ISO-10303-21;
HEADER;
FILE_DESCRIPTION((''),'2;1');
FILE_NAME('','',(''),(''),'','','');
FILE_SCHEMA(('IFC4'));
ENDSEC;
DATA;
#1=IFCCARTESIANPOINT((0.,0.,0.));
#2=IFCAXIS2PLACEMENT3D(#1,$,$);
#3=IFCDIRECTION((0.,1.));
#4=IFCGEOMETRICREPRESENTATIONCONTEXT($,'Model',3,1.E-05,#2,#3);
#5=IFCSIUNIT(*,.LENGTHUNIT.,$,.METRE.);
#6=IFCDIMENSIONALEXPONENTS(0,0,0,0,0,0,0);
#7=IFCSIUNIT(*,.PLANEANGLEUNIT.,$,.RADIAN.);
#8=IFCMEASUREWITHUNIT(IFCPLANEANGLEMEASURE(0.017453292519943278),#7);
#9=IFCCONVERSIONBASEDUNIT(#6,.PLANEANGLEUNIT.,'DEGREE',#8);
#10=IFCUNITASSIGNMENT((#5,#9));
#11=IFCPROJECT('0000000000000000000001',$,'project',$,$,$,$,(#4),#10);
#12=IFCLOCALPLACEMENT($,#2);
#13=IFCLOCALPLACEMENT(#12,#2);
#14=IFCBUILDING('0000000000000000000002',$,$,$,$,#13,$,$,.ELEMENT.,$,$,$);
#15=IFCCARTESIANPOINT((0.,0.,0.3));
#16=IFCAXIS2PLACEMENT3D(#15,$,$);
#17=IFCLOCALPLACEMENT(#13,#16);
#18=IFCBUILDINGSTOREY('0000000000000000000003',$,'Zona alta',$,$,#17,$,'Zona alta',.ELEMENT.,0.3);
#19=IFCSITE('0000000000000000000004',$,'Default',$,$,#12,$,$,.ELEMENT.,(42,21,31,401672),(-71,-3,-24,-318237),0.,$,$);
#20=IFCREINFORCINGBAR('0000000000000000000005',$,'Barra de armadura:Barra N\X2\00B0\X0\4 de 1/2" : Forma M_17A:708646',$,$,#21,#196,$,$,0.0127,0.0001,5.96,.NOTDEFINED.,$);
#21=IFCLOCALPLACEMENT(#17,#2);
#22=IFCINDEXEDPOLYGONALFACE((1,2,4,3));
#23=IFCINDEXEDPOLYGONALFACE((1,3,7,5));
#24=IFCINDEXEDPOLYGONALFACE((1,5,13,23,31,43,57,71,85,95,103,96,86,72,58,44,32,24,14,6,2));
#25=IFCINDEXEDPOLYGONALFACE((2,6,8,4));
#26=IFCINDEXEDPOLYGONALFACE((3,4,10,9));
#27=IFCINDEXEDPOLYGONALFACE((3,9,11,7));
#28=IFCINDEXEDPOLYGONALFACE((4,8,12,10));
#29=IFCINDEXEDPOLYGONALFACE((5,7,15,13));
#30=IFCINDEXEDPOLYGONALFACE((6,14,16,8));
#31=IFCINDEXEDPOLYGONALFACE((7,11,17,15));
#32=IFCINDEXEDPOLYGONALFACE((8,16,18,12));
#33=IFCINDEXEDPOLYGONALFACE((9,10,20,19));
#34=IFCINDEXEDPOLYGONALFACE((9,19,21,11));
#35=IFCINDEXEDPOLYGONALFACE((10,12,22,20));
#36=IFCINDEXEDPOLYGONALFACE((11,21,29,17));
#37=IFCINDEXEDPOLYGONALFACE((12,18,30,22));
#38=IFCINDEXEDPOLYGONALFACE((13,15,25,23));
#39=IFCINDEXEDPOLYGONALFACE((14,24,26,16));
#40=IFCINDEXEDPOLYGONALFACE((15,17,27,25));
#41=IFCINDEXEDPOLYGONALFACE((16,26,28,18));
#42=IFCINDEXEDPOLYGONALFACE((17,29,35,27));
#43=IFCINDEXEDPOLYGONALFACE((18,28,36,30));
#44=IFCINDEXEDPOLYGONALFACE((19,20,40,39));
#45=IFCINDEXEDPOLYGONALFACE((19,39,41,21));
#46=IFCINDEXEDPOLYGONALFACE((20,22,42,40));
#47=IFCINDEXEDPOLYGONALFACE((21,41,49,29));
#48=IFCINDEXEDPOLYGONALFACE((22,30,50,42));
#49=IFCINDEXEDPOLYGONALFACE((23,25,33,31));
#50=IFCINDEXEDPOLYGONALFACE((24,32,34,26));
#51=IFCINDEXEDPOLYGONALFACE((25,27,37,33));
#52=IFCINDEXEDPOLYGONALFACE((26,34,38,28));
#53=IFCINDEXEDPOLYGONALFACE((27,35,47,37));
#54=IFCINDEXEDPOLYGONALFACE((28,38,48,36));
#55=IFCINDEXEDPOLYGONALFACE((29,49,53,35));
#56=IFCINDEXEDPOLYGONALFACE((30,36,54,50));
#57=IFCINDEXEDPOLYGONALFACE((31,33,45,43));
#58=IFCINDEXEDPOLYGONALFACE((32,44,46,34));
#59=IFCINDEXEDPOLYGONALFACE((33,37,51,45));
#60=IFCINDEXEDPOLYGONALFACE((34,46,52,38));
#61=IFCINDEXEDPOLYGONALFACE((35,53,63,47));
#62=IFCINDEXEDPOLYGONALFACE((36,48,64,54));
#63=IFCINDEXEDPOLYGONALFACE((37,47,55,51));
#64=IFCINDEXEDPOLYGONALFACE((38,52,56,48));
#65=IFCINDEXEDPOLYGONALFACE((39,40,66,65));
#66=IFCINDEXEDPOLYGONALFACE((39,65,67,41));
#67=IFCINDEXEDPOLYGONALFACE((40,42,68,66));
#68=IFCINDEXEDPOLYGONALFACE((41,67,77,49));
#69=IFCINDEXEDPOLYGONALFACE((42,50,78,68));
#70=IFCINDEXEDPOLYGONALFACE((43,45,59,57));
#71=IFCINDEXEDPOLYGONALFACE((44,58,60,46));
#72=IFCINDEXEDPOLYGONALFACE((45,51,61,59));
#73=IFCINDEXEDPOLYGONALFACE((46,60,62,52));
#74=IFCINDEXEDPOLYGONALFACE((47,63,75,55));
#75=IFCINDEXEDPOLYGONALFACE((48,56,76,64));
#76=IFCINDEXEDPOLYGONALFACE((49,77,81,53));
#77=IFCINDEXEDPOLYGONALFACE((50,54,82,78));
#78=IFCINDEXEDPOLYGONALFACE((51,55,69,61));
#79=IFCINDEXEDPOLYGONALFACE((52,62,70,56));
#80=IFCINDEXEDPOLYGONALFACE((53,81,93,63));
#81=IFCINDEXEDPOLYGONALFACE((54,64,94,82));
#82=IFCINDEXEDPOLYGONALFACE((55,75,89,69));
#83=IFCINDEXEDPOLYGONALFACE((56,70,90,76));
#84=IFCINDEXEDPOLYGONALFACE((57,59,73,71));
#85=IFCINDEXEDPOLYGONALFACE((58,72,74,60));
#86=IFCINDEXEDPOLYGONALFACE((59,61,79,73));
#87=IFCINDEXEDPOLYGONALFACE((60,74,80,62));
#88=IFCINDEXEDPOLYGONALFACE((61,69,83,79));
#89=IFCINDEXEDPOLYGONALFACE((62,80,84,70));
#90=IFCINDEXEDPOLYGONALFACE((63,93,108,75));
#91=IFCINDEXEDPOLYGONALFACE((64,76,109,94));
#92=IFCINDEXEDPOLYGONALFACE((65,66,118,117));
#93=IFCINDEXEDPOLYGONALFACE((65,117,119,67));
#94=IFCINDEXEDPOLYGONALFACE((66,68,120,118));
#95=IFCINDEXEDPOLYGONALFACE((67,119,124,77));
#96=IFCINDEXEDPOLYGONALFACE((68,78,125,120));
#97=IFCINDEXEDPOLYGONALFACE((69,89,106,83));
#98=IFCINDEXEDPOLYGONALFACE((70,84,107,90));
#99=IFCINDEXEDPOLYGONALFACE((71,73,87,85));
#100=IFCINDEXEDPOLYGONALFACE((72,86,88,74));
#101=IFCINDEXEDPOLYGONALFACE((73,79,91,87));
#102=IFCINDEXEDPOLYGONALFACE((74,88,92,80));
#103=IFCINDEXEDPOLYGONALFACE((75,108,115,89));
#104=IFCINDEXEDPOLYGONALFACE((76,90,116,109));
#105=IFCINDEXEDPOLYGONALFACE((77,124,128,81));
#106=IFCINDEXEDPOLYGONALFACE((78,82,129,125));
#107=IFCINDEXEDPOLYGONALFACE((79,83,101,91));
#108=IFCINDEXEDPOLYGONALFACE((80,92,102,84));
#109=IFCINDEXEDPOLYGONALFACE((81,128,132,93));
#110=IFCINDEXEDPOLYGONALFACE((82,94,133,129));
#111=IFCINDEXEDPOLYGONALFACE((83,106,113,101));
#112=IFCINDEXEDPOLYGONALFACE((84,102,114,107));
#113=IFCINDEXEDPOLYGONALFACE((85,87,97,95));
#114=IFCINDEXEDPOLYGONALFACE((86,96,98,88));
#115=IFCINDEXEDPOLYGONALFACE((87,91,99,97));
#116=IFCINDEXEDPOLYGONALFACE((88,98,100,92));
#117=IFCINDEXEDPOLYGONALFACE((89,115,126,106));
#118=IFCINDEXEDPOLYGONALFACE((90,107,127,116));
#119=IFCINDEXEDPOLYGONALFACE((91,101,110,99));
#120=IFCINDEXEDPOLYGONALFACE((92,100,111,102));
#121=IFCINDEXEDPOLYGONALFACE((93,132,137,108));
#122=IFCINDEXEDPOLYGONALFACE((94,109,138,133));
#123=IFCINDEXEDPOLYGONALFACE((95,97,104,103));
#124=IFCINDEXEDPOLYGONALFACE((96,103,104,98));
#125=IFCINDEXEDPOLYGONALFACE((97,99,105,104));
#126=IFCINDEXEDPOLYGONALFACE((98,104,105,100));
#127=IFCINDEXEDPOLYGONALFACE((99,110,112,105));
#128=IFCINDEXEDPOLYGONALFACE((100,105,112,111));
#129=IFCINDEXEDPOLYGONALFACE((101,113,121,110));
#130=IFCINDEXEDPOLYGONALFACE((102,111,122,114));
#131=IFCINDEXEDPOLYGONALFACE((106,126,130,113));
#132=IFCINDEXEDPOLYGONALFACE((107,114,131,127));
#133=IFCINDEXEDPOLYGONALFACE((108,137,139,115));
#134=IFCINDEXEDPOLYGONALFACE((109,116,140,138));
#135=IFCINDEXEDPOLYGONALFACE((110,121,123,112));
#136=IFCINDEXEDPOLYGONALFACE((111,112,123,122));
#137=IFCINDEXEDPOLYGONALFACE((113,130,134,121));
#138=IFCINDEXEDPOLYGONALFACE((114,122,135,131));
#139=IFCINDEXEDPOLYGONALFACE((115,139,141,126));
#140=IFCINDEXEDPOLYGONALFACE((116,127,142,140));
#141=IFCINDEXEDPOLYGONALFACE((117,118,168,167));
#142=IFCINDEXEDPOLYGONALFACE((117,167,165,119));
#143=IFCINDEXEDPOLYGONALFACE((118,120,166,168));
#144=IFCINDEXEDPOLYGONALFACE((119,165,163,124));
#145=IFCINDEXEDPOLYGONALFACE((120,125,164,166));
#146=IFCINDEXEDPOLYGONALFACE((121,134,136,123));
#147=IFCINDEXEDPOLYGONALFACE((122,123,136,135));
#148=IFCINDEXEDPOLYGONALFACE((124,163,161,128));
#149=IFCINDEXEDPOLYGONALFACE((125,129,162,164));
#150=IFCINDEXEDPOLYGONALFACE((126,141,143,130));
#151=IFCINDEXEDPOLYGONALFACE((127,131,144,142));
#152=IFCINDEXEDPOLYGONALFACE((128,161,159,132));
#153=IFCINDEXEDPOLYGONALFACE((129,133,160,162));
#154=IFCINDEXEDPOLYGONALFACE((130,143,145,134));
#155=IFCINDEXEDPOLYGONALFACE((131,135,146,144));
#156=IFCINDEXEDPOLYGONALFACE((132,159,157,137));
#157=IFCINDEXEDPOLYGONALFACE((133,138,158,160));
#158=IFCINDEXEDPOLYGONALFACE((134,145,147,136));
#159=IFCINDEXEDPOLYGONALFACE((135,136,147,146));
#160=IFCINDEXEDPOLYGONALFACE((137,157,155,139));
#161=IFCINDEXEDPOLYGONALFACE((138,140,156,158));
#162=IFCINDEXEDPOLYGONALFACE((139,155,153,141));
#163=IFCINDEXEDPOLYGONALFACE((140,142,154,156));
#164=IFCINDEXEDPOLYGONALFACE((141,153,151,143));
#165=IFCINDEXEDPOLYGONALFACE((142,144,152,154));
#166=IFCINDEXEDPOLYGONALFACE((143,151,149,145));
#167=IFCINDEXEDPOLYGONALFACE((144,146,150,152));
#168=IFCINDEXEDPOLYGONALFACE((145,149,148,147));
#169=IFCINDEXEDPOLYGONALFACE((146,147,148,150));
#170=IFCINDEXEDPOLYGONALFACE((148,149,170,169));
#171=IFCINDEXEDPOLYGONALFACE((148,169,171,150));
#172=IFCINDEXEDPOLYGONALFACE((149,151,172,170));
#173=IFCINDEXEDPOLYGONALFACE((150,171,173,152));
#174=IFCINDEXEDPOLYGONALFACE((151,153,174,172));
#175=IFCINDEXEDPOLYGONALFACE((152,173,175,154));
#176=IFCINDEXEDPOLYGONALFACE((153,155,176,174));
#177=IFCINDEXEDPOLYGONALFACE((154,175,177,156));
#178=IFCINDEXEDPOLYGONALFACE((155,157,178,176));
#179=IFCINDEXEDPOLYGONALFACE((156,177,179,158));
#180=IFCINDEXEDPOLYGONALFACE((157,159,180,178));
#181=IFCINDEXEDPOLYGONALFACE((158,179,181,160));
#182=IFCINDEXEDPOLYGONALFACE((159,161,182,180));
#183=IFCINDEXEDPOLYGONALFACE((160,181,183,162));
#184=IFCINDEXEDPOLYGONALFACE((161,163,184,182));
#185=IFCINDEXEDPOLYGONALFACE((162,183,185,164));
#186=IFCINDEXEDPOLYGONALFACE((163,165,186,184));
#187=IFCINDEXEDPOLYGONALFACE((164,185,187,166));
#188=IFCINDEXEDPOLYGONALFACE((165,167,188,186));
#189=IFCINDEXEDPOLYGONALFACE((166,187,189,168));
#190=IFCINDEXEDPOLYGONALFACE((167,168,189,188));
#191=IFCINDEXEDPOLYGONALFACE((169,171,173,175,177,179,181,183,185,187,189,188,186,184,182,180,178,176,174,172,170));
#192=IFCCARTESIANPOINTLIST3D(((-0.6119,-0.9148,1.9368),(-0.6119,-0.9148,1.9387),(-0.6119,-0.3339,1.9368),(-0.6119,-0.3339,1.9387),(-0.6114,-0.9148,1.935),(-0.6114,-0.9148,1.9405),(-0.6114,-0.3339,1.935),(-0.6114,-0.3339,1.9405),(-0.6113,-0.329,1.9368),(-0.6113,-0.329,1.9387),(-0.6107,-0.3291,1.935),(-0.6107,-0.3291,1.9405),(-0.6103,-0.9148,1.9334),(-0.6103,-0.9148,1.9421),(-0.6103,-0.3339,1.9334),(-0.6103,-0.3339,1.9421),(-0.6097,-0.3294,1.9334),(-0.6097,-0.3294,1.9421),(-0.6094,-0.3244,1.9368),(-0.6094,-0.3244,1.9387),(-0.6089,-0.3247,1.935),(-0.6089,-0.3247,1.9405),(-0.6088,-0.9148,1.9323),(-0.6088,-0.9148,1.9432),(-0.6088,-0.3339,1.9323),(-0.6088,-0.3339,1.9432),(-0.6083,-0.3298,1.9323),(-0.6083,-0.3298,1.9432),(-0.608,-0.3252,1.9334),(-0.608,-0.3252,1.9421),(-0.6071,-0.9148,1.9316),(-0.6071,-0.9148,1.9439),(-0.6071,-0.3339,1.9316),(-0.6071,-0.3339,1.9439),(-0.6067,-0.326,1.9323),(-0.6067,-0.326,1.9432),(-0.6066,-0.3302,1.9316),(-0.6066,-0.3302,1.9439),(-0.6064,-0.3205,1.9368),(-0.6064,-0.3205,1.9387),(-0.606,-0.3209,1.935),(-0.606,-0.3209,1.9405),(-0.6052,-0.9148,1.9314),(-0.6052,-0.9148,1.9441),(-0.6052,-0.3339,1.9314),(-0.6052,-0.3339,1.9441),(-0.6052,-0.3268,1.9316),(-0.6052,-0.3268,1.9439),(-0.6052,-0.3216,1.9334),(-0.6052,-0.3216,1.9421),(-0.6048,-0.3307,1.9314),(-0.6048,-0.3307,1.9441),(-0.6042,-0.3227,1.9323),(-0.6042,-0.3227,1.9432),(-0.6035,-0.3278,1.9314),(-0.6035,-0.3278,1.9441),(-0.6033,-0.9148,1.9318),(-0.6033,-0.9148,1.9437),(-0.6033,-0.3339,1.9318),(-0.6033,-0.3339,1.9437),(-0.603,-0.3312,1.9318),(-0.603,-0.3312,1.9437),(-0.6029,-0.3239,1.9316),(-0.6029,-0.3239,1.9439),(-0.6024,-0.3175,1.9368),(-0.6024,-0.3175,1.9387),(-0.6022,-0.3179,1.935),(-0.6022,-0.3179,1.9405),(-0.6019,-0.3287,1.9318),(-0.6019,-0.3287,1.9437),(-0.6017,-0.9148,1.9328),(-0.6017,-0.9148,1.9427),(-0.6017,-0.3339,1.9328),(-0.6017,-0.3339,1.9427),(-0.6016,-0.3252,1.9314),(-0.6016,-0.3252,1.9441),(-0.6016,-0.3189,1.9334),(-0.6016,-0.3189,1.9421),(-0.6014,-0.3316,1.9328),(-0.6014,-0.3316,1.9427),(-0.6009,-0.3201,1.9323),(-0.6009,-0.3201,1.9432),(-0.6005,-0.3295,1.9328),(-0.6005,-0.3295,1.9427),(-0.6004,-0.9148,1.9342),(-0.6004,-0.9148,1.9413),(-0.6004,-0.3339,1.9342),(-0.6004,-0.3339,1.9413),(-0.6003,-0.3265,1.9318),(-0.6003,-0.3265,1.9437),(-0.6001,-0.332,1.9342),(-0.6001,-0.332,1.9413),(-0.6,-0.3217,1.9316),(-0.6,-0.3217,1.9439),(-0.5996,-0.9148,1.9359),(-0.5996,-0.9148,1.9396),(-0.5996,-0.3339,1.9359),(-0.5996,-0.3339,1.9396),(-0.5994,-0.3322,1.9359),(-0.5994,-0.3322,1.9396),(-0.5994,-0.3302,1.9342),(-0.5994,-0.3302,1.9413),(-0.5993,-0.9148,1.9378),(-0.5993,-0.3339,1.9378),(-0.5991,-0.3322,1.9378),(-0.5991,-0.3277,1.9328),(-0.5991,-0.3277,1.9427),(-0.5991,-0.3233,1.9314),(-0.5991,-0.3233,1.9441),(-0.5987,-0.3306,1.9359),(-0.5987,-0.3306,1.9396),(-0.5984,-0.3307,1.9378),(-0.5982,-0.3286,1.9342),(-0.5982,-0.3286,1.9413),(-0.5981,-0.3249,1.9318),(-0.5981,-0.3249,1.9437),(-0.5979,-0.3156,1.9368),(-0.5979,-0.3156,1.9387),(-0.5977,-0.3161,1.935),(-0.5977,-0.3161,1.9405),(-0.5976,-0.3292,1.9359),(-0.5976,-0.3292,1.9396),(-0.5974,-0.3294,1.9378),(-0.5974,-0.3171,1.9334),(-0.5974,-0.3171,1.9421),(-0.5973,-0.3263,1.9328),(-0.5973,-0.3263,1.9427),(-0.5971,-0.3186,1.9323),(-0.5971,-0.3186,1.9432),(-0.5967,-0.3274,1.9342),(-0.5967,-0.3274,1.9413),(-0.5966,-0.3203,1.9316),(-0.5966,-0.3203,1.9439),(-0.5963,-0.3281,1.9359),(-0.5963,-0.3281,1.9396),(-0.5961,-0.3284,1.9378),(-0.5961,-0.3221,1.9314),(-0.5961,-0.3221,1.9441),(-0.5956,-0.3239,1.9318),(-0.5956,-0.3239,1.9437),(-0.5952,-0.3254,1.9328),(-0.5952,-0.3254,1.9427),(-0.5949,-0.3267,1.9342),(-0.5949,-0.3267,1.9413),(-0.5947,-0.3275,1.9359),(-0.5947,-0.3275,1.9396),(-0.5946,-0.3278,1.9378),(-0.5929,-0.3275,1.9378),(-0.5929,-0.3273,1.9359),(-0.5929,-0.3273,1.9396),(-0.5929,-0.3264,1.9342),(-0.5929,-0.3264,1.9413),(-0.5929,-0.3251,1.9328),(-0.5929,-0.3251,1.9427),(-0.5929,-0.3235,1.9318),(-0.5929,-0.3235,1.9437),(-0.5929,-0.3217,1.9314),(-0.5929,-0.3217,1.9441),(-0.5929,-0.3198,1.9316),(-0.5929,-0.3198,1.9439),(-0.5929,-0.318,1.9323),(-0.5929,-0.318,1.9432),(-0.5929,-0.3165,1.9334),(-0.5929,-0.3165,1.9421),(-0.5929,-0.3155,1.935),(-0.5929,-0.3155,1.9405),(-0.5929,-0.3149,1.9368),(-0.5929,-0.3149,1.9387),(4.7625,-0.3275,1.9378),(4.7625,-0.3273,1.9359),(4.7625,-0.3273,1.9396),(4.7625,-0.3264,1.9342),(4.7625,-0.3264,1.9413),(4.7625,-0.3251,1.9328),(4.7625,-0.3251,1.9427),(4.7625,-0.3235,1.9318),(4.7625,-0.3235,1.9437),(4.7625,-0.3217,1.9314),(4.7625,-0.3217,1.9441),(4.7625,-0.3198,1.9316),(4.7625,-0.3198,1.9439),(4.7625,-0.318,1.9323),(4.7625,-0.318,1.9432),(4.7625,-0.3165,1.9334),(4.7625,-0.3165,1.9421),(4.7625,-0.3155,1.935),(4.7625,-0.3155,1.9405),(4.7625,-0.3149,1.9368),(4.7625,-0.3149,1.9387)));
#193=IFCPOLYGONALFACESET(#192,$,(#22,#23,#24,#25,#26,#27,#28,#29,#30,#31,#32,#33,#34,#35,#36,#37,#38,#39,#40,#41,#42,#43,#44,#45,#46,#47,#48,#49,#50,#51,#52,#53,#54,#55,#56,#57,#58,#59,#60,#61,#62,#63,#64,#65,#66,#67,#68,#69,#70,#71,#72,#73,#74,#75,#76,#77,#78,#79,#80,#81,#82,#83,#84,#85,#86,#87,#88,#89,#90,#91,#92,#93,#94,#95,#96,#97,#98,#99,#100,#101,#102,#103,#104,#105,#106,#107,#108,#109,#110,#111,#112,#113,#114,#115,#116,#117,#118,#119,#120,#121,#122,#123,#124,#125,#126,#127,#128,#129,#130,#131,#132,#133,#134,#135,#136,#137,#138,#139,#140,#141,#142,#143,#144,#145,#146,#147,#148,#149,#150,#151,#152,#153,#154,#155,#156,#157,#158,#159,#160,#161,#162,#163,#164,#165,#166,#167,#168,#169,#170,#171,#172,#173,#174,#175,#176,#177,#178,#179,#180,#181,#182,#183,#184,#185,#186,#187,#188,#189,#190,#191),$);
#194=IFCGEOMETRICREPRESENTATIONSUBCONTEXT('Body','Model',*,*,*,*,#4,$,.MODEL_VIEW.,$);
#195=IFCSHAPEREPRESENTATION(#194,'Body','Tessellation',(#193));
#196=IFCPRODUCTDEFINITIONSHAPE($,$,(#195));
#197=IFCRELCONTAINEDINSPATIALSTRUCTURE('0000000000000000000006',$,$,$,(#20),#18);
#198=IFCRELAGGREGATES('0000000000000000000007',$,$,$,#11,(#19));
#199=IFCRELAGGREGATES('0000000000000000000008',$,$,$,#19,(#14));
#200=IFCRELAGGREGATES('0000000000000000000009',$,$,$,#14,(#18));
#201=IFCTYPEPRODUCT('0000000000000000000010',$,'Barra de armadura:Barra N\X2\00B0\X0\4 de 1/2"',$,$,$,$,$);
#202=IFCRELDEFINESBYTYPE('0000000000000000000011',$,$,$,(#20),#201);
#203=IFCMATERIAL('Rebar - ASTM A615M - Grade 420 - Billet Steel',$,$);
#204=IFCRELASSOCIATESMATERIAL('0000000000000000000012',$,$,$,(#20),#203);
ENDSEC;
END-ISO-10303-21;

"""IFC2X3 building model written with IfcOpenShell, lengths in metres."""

from ifc_helpers import new_model, entity, si_unit, converted_unit, direction, frame, origin, place, context, subcontext, project, spatial, material, type_object, element, save


model = new_model("IFC2X3")

# Units and contexts
model_context = context("Model", 3, precision=1e-05, world=origin(), true_north=direction((0.0, 1.0)))
body_context = subcontext(model_context, "Body", "Model", "MODEL_VIEW")
ifc_project = project(units=[si_unit("LENGTHUNIT", "METRE"), converted_unit("PLANEANGLEUNIT", "DEGREE", entity("IfcPlaneAngleMeasure", 0.017453292519943278), si_unit("PLANEANGLEUNIT", "RADIAN"), dimensions=[0, 0, 0, 0, 0, 0, 0])], contexts=[model_context])

# Site, building, storey
site_placement = place(None, origin())
site = spatial("IfcSite", under=ifc_project, at=site_placement, Name="Default", CompositionType="ELEMENT", RefLatitude=(42, 21, 31, 401672), RefLongitude=(-71, -3, -24, -318237), RefElevation=0.0)
building_placement = place(site_placement, origin())
building = spatial("IfcBuilding", under=site, at=building_placement, CompositionType="ELEMENT")
storey_placement = place(building_placement, frame((0.0, 0.0, 0.3)))
storey = spatial("IfcBuildingStorey", under=building, at=storey_placement, Name="Zona alta", LongName="Zona alta", CompositionType="ELEMENT", Elevation=0.3)

# Reinforcing bar
ifc_material = material(Name="Rebar - ASTM A615M - Grade 420 - Billet Steel")
type_product_1 = type_object("IfcTypeProduct", Name="Barra de armadura:Barra N°4 de 1/2\"")
reinforcing_bar_1_placement = place(storey_placement, origin())
element("IfcReinforcingBar", 1, at=reinforcing_bar_1_placement, inside=storey, type_object=type_product_1, material=ifc_material, Name="Barra de armadura:Barra N°4 de 1/2\" : Forma M_17A:708646", BarLength=5.96, BarRole="NOTDEFINED", CrossSectionArea=0.0001, NominalDiameter=0.0127, context=body_context, shape_type="AdvancedSweptSolid", body=[
    entity("IfcSweptDiskSolid", entity("IfcCompositeCurve", [entity("IfcCompositeCurveSegment", "CONTINUOUS", True, entity("IfcPolyline", [entity("IfcCartesianPoint", [4.7625, -0.3212, 1.9378]), entity("IfcCartesianPoint", [-0.5929, -0.3212, 1.9378])])), entity("IfcCompositeCurveSegment", "CONTINUOUS", True, entity("IfcTrimmedCurve", entity("IfcCircle", entity("IfcAxis2Placement3D", entity("IfcCartesianPoint", [-0.5929, -0.3339, 1.9378]), entity("IfcDirection", [0.0, 0.0, 1.0]), entity("IfcDirection", [-1.0, 0.0, 0.0])), 0.0127), [entity("IfcParameterValue", 270.0)], [entity("IfcParameterValue", 360.0)], True, "PARAMETER")), entity("IfcCompositeCurveSegment", "CONTINUOUS", True, entity("IfcPolyline", [entity("IfcCartesianPoint", [-0.6056, -0.3339, 1.9378]), entity("IfcCartesianPoint", [-0.6056, -0.9148, 1.9378])]))], False), 0.0063, None, 0.0, 92.0),
])

save(model, "model.ifc")
